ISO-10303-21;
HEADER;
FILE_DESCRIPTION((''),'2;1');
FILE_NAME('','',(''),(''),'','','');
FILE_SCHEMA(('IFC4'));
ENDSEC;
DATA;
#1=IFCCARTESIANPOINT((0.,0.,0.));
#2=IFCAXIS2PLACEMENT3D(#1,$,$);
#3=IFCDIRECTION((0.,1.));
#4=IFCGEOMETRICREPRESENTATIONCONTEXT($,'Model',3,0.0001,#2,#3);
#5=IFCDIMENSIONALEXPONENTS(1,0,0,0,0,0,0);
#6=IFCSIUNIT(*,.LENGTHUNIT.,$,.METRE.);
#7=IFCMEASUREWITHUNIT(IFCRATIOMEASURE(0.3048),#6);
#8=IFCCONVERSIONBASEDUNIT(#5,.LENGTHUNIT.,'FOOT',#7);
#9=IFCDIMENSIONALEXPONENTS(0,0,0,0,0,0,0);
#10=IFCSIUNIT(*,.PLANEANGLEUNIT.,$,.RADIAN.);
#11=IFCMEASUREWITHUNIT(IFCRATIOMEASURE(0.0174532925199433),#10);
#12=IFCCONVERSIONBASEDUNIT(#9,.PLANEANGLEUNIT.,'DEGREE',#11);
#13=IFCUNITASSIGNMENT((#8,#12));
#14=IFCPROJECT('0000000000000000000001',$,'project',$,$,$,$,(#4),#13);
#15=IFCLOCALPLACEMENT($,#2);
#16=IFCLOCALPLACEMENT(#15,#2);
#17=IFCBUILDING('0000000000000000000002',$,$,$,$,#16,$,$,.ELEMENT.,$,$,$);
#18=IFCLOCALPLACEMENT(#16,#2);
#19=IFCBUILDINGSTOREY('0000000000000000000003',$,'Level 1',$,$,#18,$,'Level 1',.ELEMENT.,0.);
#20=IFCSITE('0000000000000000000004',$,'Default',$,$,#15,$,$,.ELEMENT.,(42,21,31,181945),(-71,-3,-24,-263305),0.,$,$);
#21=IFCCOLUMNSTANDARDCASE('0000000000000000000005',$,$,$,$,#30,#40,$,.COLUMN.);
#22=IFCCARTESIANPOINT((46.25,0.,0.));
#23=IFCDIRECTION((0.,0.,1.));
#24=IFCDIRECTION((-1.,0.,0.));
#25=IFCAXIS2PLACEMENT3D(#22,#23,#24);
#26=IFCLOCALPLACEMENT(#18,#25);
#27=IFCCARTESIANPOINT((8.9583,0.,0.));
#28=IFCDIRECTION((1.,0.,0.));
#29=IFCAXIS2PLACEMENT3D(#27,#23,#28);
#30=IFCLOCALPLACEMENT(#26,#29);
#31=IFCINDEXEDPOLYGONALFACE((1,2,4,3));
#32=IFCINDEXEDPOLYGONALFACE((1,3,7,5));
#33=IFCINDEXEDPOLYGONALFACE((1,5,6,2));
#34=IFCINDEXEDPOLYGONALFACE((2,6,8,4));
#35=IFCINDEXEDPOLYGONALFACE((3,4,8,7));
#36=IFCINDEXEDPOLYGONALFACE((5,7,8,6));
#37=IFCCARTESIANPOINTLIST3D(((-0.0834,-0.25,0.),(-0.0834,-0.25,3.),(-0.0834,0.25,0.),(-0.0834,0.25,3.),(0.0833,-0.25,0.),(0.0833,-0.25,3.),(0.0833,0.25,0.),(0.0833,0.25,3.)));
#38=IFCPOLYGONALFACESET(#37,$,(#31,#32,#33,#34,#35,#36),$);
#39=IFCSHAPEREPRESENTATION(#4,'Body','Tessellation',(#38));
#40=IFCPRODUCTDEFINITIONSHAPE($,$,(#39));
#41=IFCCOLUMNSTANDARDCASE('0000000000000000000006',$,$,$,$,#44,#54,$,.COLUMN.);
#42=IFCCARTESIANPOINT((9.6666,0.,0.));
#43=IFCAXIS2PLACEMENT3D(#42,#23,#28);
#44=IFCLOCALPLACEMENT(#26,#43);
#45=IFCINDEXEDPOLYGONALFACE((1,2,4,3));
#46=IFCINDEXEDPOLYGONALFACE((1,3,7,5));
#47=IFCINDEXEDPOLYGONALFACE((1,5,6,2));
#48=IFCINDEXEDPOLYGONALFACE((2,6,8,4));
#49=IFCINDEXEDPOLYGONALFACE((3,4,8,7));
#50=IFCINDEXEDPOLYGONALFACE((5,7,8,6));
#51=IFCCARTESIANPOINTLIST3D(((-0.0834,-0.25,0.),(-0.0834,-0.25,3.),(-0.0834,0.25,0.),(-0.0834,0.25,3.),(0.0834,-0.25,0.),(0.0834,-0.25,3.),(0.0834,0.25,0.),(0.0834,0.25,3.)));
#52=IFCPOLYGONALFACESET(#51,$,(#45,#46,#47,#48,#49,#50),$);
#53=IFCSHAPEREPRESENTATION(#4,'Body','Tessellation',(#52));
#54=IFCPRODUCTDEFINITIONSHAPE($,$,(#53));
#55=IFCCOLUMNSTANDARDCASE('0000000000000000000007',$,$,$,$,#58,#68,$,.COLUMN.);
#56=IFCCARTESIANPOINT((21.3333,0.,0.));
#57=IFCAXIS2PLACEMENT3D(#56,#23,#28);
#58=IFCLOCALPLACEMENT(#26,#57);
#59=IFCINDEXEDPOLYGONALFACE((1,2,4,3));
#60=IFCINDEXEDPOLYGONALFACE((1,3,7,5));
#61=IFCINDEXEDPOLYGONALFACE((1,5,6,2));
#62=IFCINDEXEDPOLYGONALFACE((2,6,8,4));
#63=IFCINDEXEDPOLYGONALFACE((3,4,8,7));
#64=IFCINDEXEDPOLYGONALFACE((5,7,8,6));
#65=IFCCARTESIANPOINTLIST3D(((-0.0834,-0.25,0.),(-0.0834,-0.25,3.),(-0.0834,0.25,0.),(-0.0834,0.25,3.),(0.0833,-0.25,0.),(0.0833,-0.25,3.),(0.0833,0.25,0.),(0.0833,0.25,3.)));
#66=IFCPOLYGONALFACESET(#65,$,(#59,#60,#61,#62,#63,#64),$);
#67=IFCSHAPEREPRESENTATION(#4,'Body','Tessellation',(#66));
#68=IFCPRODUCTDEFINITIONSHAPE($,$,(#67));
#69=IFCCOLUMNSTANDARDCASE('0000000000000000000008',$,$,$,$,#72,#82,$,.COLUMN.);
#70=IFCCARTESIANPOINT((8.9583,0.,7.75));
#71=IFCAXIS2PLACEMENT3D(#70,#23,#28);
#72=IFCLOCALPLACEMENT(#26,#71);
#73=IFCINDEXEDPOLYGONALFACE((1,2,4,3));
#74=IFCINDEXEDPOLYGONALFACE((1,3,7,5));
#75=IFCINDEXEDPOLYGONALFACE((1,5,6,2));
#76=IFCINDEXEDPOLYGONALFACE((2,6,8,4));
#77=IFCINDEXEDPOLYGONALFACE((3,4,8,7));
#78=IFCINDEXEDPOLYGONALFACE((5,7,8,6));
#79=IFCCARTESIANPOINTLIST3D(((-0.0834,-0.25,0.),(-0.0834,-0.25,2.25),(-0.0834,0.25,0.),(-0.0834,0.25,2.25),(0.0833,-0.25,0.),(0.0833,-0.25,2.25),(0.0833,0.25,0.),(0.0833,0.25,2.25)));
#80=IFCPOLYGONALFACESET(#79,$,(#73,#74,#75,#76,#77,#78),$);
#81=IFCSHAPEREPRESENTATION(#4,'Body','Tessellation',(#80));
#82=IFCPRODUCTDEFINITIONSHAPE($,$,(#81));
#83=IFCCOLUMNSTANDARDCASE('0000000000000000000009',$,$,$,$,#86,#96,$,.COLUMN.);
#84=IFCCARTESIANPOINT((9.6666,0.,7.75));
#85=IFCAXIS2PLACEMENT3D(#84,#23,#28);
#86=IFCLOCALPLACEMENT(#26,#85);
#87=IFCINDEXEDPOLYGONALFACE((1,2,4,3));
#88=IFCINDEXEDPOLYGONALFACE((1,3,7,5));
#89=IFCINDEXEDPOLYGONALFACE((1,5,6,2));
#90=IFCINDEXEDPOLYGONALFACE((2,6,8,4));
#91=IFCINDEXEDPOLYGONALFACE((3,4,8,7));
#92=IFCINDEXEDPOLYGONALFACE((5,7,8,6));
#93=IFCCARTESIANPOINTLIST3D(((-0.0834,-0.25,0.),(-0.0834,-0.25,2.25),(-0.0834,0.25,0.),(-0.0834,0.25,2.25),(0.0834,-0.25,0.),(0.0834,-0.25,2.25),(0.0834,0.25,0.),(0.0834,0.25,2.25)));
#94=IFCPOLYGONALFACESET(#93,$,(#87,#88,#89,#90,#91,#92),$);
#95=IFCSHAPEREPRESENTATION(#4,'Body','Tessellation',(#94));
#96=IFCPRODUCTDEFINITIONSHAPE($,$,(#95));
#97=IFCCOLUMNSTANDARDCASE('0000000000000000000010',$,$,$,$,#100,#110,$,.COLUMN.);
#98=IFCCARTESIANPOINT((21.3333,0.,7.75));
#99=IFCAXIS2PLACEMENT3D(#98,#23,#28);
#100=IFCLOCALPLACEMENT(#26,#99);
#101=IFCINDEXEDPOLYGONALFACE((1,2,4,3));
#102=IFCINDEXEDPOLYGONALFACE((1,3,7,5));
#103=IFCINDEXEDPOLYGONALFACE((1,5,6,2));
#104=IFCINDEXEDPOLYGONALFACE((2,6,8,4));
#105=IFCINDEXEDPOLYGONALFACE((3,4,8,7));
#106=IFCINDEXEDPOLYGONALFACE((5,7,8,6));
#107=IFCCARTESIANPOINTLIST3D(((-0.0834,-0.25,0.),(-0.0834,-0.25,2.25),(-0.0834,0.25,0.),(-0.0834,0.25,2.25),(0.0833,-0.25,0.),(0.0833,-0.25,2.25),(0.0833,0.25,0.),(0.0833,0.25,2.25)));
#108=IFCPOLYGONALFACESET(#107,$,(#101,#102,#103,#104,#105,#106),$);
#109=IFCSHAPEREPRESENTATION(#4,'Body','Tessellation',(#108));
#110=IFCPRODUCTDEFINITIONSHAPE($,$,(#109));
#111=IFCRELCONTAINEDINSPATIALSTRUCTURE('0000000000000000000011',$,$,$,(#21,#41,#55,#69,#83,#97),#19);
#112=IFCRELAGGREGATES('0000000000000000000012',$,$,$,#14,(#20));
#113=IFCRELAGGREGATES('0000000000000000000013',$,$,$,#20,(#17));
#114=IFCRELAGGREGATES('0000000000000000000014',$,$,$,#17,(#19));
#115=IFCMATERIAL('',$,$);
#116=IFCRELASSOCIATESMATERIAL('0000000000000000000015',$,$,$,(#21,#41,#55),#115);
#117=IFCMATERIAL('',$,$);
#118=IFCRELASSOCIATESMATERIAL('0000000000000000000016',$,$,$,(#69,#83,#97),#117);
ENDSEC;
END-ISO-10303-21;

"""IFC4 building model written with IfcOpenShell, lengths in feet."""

from ifc_helpers import new_model, entity, si_unit, converted_unit, direction, frame, origin, place, context, project, spatial, rectangle, extrude, material, element, save


model = new_model("IFC4")

# Units and contexts
model_context = context("Model", 3, precision=0.0001, world=origin(), true_north=direction((0.0, 1.0)))
ifc_project = project(units=[converted_unit("LENGTHUNIT", "FOOT", entity("IfcRatioMeasure", 0.3048), si_unit("LENGTHUNIT", "METRE"), dimensions=[1, 0, 0, 0, 0, 0, 0]), converted_unit("PLANEANGLEUNIT", "DEGREE", entity("IfcRatioMeasure", 0.0174532925199433), si_unit("PLANEANGLEUNIT", "RADIAN"), dimensions=[0, 0, 0, 0, 0, 0, 0])], contexts=[model_context])

# Site, building, storey
site_placement = place(None, origin())
site = spatial("IfcSite", under=ifc_project, at=site_placement, Name="Default", CompositionType="ELEMENT", RefLatitude=(42, 21, 31, 181945), RefLongitude=(-71, -3, -24, -263305), RefElevation=0.0)
building_placement = place(site_placement, origin())
building = spatial("IfcBuilding", under=site, at=building_placement, CompositionType="ELEMENT")
storey_placement = place(building_placement, origin())
storey = spatial("IfcBuildingStorey", under=building, at=storey_placement, Name="Level 1", LongName="Level 1", CompositionType="ELEMENT", Elevation=0.0)

# Columns
placement = place(storey_placement, frame((46.25, 0.0, 0.0), z_axis=(0.0, 0.0, 1.0), x_axis=(-1.0, 0.0, 0.0)))
ifc_material_1 = material(Name="")
for number, where, z_axis, x_axis in (
    (1, (8.9583, 0.0, 0.0), (0.0, 0.0, 1.0), (1.0, 0.0, 0.0)),
    (2, (9.6666, 0.0, 0.0), (0.0, 0.0, 1.0), (1.0, 0.0, 0.0)),
    (3, (21.3333, 0.0, 0.0), (0.0, 0.0, 1.0), (1.0, 0.0, 0.0)),
):
    element("IfcColumnStandardCase", number, at=place(placement, frame(where, z_axis=z_axis, x_axis=x_axis)), inside=storey, material=ifc_material_1, PredefinedType="COLUMN", context=model_context, shape_type="SweptSolid", body=[
        extrude(rectangle(XDim=0.1667, YDim=0.5), origin(), (0.0, 0.0, 1.0), 3.0),
    ])
ifc_material_2 = material(Name="")
for number, where, z_axis, x_axis in (
    (4, (8.9583, 0.0, 7.75), (0.0, 0.0, 1.0), (1.0, 0.0, 0.0)),
    (5, (9.6666, 0.0, 7.75), (0.0, 0.0, 1.0), (1.0, 0.0, 0.0)),
    (6, (21.3333, 0.0, 7.75), (0.0, 0.0, 1.0), (1.0, 0.0, 0.0)),
):
    element("IfcColumnStandardCase", number, at=place(placement, frame(where, z_axis=z_axis, x_axis=x_axis)), inside=storey, material=ifc_material_2, PredefinedType="COLUMN", context=model_context, shape_type="SweptSolid", body=[
        extrude(rectangle(XDim=0.1667, YDim=0.5), origin(), (0.0, 0.0, 1.0), 2.25),
    ])

save(model, "model.ifc")
